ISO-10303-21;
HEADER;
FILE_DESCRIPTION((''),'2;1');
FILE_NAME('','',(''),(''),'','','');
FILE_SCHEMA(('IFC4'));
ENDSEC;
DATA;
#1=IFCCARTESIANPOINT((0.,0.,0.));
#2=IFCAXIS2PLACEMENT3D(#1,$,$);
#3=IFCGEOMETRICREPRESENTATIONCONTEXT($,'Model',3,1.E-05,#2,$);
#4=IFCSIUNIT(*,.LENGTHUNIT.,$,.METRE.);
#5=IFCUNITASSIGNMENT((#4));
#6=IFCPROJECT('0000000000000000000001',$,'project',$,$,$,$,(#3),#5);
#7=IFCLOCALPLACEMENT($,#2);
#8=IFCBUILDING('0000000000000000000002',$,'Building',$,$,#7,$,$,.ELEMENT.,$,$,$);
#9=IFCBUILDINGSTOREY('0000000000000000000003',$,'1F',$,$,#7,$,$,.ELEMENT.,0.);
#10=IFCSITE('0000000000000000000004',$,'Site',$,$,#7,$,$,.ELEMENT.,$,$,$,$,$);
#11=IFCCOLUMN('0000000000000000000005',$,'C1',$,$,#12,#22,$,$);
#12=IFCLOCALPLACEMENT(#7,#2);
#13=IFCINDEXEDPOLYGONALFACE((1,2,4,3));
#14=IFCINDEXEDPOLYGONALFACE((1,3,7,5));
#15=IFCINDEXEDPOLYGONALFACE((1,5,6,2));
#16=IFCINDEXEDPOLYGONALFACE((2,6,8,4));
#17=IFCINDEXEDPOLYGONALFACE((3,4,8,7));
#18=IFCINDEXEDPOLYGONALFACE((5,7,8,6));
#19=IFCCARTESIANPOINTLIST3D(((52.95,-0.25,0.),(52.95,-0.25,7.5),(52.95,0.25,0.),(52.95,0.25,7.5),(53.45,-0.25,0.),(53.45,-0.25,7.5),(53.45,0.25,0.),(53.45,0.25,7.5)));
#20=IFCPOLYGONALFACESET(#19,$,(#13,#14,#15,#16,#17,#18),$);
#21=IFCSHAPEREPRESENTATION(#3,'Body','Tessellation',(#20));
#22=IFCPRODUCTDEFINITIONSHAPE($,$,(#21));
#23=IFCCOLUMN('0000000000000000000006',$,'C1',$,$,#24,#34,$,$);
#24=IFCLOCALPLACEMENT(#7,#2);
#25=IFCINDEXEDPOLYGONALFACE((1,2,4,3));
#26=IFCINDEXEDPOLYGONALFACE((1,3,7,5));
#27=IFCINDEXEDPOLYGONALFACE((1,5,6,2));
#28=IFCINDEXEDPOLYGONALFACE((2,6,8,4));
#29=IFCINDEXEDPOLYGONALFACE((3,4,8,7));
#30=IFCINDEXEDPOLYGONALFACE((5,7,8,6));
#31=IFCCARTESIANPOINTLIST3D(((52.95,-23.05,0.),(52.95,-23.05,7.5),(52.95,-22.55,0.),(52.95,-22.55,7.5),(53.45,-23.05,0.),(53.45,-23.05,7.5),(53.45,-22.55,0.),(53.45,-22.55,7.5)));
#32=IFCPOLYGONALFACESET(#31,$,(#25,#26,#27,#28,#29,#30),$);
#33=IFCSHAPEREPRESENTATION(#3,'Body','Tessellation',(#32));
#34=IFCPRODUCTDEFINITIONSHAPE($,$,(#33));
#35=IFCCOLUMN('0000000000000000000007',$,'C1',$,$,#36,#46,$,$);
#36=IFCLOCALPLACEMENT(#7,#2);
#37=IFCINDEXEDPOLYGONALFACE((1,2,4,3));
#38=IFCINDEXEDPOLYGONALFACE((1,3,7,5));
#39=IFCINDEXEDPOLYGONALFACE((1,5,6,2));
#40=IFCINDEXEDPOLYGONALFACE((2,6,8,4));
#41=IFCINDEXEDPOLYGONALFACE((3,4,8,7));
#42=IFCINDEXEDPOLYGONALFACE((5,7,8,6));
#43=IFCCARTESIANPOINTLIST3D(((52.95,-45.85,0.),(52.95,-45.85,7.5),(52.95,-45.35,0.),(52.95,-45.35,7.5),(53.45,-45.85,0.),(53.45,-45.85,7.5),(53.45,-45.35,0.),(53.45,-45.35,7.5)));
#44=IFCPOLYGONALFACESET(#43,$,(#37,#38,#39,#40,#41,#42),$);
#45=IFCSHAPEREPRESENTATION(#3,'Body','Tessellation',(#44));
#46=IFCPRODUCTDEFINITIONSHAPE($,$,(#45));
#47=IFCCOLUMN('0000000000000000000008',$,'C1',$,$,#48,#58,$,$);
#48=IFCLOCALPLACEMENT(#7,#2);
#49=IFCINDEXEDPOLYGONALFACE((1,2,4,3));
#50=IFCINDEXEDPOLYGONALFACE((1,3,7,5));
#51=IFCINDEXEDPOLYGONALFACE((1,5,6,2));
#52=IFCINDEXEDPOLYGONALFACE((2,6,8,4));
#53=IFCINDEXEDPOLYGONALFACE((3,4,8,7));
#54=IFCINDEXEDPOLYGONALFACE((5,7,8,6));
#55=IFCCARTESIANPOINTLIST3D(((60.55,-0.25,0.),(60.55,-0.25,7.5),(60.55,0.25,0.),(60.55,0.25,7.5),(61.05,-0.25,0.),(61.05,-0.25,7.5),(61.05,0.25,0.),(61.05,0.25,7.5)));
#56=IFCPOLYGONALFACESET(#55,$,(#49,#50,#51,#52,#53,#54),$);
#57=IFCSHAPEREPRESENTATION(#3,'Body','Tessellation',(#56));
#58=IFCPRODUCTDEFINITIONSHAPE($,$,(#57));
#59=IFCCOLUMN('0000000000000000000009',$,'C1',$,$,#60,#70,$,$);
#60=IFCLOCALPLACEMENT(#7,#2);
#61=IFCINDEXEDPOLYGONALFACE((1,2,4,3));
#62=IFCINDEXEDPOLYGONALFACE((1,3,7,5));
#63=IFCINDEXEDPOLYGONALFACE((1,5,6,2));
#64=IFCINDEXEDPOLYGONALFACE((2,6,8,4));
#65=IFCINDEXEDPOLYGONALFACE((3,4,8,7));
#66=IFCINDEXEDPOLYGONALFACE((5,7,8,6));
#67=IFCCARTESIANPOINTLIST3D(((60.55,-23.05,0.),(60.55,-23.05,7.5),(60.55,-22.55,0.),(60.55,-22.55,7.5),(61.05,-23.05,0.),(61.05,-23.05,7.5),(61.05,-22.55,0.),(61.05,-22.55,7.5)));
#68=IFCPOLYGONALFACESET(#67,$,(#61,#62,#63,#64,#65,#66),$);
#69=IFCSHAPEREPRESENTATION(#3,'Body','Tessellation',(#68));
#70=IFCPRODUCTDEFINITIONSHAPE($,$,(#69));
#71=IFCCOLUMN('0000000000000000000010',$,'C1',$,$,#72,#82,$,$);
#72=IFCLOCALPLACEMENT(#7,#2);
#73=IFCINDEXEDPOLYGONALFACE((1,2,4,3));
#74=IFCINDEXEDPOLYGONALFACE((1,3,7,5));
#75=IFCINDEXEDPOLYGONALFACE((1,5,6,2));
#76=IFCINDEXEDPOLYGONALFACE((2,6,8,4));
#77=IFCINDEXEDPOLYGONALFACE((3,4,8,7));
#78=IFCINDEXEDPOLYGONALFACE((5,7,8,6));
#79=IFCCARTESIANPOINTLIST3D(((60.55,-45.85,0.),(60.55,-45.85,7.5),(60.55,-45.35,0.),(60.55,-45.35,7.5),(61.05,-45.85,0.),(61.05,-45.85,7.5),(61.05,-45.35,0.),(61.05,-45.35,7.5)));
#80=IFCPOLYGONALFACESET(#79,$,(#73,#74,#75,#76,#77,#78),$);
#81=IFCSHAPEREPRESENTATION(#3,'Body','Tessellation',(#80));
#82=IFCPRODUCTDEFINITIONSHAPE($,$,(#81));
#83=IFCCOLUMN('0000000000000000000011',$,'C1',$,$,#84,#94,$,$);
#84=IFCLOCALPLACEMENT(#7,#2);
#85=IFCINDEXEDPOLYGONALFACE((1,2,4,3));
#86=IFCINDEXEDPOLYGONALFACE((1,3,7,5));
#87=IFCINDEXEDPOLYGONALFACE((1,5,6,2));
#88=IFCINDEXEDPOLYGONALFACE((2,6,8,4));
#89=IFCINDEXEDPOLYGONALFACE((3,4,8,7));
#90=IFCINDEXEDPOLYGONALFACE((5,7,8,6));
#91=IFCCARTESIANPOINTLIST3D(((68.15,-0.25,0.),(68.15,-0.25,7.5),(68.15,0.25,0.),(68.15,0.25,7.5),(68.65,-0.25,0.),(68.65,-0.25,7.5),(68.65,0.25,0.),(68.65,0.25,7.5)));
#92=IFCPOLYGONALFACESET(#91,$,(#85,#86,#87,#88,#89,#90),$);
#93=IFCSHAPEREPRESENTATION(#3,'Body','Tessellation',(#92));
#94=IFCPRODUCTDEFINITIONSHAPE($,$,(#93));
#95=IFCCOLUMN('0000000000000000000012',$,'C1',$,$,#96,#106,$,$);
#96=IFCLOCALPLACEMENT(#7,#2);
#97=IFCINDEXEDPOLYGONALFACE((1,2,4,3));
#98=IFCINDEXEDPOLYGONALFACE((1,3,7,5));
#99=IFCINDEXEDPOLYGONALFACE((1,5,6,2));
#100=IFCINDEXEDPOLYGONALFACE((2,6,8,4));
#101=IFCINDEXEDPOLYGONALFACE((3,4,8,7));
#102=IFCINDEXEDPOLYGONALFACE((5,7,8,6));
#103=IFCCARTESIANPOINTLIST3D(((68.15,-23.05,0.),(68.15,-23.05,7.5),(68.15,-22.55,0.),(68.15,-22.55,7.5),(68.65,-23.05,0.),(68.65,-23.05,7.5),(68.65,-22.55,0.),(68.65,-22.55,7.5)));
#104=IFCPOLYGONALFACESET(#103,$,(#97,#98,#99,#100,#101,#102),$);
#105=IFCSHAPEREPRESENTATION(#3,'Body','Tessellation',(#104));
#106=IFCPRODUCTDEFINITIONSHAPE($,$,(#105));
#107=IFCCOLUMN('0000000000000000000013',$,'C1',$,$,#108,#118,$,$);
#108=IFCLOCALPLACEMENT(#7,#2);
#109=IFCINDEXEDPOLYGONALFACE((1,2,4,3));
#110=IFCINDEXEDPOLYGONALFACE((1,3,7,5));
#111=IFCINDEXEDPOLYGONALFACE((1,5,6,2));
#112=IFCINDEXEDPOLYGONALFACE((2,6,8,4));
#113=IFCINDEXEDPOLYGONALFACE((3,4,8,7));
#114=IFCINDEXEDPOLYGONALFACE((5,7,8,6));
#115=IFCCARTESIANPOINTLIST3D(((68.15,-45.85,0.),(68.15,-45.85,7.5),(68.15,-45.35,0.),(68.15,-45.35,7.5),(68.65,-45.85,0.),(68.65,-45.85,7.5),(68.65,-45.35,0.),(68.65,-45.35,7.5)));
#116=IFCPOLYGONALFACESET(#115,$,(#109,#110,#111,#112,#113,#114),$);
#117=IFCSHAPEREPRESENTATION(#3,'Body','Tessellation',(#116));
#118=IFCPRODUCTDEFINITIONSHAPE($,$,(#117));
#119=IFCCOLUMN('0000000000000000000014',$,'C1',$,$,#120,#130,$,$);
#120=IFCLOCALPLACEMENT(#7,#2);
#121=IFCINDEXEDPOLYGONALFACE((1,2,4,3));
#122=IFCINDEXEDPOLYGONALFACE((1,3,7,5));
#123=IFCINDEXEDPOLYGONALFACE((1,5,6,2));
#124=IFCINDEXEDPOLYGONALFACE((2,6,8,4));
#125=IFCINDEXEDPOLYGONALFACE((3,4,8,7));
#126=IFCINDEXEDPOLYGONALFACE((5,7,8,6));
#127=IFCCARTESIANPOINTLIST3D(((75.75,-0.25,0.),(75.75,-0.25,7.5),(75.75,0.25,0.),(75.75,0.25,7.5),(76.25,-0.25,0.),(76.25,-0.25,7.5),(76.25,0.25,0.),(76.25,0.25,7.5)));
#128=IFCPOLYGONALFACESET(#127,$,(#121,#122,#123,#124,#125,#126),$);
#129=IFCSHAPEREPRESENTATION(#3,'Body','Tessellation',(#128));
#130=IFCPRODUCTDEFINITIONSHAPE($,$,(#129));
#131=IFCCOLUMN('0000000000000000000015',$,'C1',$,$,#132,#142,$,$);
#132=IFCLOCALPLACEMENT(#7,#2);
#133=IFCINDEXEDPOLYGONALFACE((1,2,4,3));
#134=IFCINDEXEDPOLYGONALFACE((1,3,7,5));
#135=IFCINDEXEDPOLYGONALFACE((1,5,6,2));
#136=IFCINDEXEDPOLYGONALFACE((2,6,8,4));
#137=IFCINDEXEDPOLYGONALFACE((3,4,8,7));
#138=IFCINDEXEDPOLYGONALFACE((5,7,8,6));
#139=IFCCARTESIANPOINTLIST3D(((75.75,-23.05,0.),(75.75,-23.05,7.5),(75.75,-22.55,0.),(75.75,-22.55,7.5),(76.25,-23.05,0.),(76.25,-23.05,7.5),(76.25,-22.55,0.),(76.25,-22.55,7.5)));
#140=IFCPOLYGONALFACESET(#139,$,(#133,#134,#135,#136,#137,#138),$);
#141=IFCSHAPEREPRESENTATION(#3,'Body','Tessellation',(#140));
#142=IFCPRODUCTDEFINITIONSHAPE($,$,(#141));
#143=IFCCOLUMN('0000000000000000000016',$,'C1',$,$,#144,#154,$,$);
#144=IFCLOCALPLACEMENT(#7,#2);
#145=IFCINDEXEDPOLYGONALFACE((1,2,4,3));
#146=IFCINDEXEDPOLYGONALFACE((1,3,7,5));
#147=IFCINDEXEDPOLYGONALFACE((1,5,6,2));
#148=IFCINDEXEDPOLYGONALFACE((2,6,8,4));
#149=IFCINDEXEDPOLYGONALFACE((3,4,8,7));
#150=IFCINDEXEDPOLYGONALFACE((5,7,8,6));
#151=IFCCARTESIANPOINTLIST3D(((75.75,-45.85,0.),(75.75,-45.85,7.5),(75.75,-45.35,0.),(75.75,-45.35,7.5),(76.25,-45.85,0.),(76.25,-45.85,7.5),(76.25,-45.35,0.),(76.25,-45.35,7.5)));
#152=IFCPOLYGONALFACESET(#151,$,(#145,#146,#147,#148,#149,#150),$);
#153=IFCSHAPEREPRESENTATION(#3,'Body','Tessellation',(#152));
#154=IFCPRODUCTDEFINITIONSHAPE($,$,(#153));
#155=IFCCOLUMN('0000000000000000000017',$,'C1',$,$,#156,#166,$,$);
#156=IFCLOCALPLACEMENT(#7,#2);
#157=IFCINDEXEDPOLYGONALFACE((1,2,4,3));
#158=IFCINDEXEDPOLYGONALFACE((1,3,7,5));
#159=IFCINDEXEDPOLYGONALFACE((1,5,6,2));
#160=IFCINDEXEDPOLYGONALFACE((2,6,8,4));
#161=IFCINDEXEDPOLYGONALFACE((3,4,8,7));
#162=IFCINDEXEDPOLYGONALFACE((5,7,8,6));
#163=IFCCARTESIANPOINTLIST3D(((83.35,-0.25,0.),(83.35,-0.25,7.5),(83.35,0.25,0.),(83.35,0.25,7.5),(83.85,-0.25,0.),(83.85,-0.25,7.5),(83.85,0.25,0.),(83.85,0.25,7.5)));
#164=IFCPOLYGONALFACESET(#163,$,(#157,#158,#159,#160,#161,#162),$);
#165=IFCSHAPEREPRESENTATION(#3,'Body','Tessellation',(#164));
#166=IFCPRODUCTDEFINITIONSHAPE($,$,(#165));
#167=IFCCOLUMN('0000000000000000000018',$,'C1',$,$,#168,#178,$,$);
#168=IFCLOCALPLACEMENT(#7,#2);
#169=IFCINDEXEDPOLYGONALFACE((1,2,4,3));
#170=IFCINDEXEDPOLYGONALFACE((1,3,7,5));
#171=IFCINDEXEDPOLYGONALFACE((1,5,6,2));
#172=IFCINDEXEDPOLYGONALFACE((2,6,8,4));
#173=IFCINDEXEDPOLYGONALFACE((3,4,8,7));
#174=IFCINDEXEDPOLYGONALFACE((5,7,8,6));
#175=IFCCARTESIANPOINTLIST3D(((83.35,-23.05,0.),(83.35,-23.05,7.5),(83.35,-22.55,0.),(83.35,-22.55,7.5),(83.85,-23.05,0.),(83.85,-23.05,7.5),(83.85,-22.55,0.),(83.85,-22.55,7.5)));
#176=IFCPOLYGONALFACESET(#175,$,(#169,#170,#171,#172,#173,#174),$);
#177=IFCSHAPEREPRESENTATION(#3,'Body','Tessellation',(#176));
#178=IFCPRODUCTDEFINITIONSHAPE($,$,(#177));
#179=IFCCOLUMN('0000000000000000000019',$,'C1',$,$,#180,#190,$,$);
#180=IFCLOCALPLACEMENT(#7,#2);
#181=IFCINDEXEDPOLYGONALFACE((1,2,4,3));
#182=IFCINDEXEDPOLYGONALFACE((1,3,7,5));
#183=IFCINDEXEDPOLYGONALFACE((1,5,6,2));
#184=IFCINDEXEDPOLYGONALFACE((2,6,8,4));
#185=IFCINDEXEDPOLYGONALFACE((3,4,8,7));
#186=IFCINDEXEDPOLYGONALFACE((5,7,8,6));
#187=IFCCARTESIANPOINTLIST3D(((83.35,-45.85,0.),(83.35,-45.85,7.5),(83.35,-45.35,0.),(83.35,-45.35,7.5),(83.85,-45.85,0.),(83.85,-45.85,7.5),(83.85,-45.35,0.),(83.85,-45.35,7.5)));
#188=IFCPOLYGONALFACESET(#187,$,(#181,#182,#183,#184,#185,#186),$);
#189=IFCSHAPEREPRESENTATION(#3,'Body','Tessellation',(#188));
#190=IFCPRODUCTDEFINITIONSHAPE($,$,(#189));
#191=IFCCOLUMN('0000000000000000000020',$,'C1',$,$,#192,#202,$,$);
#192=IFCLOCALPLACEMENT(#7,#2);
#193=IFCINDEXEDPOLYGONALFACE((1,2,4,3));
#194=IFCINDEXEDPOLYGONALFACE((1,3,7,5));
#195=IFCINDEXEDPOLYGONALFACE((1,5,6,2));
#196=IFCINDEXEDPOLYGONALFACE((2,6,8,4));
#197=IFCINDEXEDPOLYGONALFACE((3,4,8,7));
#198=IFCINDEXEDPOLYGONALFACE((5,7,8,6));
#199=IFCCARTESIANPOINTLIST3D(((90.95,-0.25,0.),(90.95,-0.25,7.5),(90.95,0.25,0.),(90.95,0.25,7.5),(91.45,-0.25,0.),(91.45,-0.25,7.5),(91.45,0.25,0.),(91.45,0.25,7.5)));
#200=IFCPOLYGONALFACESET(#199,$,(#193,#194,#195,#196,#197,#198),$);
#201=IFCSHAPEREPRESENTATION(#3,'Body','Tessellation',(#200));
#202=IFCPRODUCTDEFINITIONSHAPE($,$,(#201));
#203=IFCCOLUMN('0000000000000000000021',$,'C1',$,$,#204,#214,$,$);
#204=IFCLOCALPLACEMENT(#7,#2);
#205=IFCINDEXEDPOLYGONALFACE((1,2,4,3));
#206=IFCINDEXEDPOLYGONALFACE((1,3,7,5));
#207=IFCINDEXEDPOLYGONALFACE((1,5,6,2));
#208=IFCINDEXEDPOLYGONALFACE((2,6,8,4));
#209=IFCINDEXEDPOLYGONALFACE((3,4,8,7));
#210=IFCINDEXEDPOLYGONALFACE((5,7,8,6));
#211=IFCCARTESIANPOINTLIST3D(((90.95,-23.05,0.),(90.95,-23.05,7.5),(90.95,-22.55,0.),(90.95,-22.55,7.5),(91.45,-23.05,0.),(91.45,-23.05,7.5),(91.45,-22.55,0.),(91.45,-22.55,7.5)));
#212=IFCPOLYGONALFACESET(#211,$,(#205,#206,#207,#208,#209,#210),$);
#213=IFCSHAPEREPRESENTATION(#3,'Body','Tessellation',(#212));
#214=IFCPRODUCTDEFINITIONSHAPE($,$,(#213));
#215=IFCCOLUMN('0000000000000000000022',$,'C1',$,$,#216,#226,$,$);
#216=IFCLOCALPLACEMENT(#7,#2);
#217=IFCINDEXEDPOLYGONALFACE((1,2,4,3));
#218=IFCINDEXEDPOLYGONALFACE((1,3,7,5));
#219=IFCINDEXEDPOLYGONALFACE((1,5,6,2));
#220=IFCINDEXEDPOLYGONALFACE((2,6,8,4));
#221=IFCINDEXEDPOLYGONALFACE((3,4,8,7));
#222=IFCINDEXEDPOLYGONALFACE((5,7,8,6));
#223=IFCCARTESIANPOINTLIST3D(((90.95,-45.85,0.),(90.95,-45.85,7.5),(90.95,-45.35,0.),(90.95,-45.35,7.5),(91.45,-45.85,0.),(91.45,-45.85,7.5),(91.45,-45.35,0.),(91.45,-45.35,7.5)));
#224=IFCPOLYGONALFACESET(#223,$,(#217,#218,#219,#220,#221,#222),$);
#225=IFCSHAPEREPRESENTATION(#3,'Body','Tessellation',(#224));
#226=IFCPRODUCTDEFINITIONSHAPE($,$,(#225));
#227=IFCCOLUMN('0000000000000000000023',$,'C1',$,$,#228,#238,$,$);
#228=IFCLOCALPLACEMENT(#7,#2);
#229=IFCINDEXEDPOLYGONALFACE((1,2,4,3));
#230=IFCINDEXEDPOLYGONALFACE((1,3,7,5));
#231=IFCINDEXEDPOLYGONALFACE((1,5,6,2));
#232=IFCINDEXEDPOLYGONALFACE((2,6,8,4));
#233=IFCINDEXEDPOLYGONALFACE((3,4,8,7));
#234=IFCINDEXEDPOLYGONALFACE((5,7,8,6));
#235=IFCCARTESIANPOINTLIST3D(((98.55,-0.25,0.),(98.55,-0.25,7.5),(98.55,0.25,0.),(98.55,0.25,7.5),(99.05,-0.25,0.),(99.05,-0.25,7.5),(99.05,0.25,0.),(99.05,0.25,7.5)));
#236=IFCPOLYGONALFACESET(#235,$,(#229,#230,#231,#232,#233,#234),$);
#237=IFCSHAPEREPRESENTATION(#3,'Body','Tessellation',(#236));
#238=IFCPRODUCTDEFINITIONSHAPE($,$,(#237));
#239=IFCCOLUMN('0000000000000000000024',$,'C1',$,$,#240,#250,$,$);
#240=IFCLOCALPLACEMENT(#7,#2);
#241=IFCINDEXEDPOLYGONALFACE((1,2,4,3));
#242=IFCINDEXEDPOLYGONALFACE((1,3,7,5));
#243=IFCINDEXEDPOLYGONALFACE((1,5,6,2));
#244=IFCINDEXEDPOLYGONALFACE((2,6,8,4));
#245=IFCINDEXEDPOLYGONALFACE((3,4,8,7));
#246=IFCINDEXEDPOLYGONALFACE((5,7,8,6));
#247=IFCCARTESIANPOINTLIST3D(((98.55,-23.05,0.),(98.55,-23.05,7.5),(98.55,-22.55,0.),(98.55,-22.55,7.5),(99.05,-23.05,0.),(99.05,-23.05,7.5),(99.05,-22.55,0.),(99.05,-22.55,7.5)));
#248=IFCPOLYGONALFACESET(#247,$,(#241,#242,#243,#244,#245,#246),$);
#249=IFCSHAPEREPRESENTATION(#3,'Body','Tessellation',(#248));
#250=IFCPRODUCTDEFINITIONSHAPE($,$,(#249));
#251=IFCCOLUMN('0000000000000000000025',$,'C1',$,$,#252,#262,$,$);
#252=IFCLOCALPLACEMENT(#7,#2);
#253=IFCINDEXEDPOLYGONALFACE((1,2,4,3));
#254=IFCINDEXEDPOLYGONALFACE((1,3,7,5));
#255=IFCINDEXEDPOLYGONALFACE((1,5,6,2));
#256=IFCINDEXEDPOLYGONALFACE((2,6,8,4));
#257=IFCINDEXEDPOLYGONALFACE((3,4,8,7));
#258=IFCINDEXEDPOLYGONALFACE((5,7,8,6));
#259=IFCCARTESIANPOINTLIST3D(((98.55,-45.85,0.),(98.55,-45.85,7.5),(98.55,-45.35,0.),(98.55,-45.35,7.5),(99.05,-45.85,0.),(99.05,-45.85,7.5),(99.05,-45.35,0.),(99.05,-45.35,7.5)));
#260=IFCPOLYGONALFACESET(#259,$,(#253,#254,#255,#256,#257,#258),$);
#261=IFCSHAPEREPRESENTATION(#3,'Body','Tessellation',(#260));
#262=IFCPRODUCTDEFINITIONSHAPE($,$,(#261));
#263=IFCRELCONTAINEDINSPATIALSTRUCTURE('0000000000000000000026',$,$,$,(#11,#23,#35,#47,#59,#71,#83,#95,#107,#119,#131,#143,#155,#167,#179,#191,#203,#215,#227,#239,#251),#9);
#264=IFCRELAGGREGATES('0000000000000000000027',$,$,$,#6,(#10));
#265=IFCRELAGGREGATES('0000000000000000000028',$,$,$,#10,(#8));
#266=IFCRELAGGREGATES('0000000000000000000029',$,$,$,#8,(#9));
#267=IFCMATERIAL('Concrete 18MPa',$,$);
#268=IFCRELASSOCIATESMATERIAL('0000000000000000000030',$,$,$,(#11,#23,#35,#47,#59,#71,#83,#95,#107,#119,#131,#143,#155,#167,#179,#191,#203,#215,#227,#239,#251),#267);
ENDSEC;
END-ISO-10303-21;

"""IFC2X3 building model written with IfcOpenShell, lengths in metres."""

from ifc_helpers import new_model, si_unit, frame, origin, origin_2d, place, context, project, spatial, rectangle, extrude, material, element, save


model = new_model("IFC2X3")

# Units and contexts
model_context = context("Model", 3, precision=1e-05, world=origin())
ifc_project = project(units=[si_unit("LENGTHUNIT", "METRE")], contexts=[model_context])

# Site, building, storey
placement = place(None, origin())
site = spatial("IfcSite", under=ifc_project, at=placement, Name="Site", CompositionType="ELEMENT")
building = spatial("IfcBuilding", under=site, at=placement, Name="Building", CompositionType="ELEMENT")
storey = spatial("IfcBuildingStorey", under=building, at=placement, Name="1F", CompositionType="ELEMENT", Elevation=0.0)

# Columns
ifc_material = material(Name="Concrete 18MPa")
for number, where, name in (
    (1, (53.2, 0.0, 0.0), "C1"),
    (2, (53.2, -22.8, 0.0), "C1"),
    (3, (53.2, -45.6, 0.0), "C1"),
    (4, (60.8, 0.0, 0.0), "C1"),
    (5, (60.8, -22.8, 0.0), "C1"),
    (6, (60.8, -45.6, 0.0), "C1"),
    (7, (68.4, 0.0, 0.0), "C1"),
    (8, (68.4, -22.8, 0.0), "C1"),
    (9, (68.4, -45.6, 0.0), "C1"),
    (10, (76.0, 0.0, 0.0), "C1"),
    (11, (76.0, -22.8, 0.0), "C1"),
    (12, (76.0, -45.6, 0.0), "C1"),
    (13, (83.6, 0.0, 0.0), "C1"),
    (14, (83.6, -22.8, 0.0), "C1"),
    (15, (83.6, -45.6, 0.0), "C1"),
    (16, (91.2, 0.0, 0.0), "C1"),
    (17, (91.2, -22.8, 0.0), "C1"),
    (18, (91.2, -45.6, 0.0), "C1"),
    (19, (98.8, 0.0, 0.0), "C1"),
    (20, (98.8, -22.8, 0.0), "C1"),
    (21, (98.8, -45.6, 0.0), "C1"),
):
    element("IfcColumn", number, at=place(None, frame(where)), inside=storey, material=ifc_material, Name=name, context=model_context, shape_type="SweptSolid", body=[
        extrude(rectangle(XDim=0.5, YDim=0.5, at=origin_2d()), origin(), (0.0, 0.0, 1.0), 7.5),
    ])

save(model, "model.ifc")
